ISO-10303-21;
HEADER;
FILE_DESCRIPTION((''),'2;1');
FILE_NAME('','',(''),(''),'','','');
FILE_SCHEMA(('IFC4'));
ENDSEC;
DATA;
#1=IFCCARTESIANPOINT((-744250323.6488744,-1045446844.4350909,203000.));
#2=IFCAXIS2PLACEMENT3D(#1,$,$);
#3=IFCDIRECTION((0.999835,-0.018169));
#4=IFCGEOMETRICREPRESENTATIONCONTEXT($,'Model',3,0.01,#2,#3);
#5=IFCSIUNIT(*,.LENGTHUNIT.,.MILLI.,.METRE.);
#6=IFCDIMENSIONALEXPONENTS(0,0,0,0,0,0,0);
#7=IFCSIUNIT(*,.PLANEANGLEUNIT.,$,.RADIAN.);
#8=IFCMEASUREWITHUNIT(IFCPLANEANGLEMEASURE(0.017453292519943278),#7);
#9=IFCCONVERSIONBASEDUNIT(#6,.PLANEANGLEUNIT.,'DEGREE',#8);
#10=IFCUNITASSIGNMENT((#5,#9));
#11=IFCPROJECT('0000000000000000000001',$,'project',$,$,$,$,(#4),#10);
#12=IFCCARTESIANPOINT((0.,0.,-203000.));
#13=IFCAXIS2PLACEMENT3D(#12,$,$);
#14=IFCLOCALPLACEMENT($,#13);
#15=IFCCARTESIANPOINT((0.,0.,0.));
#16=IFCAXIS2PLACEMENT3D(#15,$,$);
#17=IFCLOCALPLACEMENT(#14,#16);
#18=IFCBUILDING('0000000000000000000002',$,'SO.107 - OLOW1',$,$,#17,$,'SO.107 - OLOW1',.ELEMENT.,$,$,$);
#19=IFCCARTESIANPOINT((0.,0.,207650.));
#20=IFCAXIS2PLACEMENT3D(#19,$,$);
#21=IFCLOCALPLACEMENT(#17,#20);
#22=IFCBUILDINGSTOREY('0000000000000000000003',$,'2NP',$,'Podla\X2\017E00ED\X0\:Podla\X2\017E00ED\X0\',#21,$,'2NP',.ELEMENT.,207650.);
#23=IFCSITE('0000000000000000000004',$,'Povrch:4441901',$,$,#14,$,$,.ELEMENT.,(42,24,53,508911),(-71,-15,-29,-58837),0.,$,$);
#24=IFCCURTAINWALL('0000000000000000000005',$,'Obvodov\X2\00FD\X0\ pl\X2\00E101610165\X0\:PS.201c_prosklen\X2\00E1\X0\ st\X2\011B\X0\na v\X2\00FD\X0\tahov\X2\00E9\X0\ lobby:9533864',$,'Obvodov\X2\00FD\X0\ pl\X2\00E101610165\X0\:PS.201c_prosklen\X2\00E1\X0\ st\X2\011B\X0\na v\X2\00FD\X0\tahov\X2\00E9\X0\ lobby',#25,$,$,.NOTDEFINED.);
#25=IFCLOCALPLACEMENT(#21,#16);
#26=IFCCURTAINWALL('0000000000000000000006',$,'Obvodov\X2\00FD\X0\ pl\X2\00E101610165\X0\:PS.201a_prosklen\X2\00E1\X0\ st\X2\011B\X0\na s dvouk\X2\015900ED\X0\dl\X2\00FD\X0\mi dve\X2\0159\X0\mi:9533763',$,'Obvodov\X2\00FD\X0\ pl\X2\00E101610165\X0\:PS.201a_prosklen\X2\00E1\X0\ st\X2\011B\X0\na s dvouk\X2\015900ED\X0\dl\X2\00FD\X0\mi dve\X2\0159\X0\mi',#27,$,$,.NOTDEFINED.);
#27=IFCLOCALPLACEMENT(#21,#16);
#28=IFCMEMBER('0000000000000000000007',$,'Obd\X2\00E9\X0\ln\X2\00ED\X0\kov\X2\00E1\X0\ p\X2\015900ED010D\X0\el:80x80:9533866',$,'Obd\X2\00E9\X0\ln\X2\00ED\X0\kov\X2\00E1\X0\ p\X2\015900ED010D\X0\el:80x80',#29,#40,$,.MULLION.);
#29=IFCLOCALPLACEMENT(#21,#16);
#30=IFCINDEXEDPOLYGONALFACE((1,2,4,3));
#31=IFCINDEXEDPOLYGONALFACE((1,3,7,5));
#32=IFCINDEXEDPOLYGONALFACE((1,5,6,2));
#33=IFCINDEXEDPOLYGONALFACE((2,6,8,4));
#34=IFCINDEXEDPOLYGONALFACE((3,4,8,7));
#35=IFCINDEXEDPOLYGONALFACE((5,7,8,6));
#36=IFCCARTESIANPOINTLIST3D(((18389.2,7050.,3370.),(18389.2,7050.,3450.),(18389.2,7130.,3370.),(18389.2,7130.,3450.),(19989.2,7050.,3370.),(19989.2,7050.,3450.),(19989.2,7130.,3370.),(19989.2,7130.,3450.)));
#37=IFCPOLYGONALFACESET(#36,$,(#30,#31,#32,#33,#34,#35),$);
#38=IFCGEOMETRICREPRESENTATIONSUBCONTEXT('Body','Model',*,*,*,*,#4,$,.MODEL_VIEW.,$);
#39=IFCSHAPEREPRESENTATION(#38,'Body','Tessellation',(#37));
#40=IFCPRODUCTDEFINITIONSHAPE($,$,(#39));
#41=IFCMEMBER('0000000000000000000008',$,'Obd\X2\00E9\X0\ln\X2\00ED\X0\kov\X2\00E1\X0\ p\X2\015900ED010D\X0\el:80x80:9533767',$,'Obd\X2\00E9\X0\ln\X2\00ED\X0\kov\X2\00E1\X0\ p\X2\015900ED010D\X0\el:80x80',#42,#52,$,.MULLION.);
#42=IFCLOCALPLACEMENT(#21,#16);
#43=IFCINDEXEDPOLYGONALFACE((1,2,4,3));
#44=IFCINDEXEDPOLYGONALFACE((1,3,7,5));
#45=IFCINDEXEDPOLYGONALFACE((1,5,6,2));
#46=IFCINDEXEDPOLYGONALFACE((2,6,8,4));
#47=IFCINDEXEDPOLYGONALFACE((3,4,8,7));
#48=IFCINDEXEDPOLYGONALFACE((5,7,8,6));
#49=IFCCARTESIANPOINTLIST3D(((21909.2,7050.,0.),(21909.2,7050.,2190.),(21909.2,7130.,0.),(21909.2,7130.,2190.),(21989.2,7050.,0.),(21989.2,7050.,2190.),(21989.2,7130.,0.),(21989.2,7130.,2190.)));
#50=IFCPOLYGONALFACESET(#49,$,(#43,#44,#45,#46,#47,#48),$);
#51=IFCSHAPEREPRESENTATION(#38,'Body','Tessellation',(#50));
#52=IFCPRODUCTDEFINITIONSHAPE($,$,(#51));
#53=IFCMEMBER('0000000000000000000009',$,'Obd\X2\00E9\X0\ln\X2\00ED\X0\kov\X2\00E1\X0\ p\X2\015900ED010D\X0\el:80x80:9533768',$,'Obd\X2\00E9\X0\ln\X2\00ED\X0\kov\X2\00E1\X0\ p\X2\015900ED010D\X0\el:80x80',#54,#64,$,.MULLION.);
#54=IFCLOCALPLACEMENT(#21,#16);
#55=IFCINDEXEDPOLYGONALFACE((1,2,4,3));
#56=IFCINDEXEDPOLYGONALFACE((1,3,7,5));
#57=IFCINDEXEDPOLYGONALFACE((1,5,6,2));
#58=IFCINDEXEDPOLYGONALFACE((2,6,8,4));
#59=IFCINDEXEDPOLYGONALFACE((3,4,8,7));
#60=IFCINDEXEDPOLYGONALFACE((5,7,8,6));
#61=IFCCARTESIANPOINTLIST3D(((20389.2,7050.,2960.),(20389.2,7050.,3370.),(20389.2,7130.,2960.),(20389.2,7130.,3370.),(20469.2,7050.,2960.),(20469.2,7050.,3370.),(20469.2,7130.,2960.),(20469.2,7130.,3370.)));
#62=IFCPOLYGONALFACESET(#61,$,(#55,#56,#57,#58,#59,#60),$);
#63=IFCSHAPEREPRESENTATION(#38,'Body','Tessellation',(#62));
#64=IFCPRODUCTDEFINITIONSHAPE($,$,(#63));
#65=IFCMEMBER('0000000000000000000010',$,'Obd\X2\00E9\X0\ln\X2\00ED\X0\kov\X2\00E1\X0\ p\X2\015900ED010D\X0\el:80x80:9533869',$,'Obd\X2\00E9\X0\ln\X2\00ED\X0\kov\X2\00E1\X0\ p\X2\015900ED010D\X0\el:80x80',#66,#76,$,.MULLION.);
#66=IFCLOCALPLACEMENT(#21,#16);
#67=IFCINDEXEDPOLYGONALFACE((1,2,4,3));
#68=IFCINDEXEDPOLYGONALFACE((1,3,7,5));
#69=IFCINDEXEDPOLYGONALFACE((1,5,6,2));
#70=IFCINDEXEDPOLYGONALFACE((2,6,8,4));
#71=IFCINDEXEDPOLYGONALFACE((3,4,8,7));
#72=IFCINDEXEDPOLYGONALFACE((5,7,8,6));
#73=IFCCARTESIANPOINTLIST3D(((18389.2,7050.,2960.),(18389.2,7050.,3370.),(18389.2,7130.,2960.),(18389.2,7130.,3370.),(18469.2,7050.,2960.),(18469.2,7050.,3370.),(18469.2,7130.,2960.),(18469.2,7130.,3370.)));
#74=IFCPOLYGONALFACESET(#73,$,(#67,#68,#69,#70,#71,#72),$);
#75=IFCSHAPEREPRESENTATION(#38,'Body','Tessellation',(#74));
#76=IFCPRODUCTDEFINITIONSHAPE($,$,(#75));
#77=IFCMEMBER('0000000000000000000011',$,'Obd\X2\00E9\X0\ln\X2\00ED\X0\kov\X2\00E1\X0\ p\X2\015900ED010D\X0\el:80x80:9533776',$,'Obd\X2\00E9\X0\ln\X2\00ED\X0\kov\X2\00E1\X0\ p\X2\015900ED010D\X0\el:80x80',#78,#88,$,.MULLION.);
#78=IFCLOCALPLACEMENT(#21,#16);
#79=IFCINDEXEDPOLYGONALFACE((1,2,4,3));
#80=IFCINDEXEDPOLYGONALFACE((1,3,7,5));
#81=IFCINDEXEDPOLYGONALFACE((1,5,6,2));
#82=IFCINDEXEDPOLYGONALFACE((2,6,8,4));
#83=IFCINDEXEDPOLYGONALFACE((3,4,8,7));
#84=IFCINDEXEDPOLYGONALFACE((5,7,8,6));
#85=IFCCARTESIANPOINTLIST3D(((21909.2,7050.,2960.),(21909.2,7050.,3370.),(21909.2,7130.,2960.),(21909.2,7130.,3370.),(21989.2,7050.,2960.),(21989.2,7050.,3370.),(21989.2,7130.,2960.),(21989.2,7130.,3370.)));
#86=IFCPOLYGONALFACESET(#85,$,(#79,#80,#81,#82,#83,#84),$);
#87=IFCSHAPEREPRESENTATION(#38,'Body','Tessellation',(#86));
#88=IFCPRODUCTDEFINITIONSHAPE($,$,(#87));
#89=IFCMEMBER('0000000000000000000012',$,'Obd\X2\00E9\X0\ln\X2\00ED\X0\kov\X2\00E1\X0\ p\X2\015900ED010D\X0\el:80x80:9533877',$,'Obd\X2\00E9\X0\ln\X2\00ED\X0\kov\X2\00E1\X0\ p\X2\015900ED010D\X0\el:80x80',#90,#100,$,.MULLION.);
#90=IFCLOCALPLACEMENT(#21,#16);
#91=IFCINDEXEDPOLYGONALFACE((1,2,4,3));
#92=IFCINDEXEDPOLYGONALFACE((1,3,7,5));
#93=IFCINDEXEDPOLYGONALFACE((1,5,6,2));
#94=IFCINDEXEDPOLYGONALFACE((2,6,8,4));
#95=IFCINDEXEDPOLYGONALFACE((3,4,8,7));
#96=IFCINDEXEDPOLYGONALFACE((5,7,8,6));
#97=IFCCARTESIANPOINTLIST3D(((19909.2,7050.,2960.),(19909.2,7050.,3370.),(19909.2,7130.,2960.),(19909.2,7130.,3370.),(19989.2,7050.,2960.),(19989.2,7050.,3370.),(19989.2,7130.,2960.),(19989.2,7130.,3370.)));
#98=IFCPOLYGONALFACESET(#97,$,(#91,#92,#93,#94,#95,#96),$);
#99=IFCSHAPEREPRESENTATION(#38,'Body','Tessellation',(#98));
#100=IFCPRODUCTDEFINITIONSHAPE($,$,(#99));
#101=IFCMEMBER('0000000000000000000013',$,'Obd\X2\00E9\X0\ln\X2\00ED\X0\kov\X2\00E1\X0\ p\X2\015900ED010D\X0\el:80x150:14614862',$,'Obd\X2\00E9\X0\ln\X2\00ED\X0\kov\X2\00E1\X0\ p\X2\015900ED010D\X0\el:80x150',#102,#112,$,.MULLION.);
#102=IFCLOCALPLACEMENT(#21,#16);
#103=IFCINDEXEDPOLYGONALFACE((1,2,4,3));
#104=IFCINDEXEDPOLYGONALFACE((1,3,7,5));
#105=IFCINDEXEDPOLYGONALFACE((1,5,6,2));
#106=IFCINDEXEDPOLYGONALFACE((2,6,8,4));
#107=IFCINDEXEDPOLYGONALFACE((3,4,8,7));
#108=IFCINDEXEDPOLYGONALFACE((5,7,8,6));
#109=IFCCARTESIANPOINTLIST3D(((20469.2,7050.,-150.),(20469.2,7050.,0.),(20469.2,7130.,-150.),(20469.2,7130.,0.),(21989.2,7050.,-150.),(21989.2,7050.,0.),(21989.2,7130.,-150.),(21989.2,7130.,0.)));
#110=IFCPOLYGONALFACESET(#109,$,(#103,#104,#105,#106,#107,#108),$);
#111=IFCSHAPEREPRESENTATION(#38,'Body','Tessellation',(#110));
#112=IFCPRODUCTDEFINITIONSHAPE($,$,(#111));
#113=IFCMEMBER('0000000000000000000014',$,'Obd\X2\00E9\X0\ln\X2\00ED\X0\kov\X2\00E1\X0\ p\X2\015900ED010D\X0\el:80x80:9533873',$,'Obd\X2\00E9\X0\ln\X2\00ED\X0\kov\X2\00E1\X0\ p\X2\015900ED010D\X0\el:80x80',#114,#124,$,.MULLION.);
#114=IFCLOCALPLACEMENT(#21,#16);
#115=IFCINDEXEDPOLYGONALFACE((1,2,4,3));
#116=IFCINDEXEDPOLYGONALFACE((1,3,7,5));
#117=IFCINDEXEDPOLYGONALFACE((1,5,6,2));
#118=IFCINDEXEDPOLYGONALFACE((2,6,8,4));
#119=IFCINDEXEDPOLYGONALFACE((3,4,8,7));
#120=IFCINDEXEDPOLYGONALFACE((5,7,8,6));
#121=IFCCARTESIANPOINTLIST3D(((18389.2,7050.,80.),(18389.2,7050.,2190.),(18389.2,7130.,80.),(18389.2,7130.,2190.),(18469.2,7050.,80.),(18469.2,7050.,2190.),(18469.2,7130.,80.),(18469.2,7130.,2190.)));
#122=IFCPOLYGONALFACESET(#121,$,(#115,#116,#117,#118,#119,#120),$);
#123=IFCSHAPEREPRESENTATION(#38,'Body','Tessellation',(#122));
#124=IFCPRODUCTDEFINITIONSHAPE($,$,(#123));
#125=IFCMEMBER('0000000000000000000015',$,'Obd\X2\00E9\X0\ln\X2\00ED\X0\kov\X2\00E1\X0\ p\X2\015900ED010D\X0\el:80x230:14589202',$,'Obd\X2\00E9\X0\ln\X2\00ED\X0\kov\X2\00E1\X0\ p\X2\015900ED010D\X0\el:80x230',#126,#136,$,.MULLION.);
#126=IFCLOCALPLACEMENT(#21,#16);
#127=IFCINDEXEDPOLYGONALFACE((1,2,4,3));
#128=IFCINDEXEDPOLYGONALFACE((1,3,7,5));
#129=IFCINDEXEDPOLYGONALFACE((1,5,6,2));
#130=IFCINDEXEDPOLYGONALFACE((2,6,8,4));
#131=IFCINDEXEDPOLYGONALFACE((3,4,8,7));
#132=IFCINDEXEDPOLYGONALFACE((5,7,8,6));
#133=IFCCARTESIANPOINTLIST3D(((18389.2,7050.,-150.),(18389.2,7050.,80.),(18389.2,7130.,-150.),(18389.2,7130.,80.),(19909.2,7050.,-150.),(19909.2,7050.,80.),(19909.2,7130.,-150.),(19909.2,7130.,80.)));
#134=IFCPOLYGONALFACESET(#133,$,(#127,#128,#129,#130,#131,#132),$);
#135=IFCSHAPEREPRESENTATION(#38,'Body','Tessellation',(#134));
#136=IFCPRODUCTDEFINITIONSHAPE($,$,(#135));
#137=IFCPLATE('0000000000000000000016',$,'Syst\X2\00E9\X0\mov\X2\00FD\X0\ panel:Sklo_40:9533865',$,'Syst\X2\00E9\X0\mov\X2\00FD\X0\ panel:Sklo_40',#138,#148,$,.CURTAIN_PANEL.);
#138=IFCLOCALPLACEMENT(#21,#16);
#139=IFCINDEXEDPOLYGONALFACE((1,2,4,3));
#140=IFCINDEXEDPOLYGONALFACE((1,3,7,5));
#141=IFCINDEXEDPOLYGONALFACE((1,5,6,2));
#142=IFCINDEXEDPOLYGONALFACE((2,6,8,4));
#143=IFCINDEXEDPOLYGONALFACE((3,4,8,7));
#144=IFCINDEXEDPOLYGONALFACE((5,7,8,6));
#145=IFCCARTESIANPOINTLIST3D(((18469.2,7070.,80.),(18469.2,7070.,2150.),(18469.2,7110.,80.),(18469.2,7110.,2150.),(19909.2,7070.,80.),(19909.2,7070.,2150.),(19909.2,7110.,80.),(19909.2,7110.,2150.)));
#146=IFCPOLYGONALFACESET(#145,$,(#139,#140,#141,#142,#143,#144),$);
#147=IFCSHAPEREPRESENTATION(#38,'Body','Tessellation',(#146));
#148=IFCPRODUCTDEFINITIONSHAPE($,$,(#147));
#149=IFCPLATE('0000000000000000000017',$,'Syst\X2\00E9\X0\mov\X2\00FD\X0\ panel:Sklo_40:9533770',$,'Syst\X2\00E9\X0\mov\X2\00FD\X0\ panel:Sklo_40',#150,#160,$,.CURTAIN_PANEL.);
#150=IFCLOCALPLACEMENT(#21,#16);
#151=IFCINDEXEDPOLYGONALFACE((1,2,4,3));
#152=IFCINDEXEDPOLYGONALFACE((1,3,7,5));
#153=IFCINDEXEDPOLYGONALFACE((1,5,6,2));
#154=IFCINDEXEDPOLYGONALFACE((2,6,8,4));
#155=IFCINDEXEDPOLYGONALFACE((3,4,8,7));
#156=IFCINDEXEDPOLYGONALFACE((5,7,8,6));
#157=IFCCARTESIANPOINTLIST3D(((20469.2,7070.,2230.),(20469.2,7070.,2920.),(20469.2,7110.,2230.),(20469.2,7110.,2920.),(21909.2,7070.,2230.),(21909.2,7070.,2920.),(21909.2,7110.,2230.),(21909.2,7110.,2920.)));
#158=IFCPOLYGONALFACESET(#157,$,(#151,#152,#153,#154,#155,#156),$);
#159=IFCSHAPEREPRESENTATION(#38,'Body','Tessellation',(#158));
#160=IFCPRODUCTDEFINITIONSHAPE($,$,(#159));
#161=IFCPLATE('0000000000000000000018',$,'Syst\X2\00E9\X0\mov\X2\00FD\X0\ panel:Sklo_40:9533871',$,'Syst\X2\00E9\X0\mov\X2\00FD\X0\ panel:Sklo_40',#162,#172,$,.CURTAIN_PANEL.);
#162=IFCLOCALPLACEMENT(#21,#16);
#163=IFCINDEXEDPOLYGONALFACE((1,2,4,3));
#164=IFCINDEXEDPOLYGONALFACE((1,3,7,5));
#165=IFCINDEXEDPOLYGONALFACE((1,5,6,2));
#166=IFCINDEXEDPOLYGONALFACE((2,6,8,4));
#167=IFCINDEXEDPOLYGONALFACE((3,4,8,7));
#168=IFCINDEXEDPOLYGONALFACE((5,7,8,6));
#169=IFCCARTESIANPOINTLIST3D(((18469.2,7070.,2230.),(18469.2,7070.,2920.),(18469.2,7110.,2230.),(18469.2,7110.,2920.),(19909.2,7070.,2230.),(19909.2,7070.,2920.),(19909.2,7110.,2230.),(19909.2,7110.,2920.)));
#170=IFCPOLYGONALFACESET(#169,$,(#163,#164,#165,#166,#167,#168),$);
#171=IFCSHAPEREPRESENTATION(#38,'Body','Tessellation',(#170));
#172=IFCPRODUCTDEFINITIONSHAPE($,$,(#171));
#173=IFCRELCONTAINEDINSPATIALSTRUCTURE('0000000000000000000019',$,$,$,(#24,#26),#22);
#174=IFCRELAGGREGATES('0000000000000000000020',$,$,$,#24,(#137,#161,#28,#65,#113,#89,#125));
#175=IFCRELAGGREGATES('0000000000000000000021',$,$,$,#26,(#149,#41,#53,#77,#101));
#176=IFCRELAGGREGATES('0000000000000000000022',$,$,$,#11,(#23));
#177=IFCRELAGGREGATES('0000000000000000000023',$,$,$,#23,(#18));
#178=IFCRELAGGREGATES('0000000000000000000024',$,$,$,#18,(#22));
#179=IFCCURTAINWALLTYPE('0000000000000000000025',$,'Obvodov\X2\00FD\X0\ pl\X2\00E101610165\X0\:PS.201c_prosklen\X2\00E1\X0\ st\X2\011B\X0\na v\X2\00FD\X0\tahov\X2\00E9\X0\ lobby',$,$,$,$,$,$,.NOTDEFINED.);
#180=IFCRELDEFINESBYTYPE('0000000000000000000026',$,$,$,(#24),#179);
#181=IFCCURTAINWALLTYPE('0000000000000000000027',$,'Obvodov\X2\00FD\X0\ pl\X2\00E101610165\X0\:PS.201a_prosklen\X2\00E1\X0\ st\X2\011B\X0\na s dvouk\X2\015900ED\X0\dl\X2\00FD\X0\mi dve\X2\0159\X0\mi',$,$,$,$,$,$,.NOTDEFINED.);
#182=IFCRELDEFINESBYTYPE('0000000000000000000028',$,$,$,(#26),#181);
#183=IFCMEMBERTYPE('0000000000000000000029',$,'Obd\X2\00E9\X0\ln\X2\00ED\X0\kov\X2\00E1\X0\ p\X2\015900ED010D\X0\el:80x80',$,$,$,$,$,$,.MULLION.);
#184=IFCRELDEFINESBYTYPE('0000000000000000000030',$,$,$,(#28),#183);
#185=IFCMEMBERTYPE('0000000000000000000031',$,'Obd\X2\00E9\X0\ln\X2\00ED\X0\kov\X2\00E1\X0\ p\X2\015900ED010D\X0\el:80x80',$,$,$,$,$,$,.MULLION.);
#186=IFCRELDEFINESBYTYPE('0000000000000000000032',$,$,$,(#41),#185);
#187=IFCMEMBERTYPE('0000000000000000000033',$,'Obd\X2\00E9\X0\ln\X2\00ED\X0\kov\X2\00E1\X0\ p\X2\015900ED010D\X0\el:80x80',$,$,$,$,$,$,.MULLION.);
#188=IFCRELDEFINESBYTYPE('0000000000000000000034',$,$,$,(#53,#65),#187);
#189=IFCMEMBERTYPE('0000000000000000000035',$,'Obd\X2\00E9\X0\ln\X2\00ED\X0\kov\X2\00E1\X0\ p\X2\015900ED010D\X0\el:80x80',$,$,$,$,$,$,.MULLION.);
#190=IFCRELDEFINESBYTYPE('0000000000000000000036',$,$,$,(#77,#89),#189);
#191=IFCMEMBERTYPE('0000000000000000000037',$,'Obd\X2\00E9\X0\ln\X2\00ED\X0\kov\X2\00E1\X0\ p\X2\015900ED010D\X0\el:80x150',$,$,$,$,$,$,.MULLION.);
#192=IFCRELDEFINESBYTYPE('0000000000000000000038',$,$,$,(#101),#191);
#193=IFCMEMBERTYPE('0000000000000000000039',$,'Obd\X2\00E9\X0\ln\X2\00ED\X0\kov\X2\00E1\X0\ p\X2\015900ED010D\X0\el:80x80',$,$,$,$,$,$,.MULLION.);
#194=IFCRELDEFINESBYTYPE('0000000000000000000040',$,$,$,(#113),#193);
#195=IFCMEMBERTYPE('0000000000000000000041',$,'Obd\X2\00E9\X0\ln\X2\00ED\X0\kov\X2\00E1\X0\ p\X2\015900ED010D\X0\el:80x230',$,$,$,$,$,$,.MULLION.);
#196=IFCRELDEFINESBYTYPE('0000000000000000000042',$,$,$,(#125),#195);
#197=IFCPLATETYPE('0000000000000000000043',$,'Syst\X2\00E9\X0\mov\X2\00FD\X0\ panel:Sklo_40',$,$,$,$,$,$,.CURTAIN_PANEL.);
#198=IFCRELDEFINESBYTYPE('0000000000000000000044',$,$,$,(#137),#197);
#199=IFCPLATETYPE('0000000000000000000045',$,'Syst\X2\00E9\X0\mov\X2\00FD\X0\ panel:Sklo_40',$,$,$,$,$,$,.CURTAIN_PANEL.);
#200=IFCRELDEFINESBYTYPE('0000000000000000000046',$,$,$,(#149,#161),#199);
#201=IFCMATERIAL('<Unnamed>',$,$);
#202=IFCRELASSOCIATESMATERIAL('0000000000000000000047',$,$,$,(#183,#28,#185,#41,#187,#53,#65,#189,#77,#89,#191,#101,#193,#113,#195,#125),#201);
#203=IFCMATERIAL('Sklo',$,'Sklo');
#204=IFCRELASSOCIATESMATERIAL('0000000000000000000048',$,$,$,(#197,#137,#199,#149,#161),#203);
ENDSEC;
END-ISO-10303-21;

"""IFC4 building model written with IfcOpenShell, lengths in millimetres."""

from ifc_helpers import new_model, entity, si_unit, converted_unit, direction, frame, origin, place, context, subcontext, project, spatial, indexed_curve, outline, extrude, source, transform, mapped, material, type_object, type_shapes, element, aggregate, save


model = new_model("IFC4")

# Units and contexts
model_context = context("Model", 3, precision=0.01, world=frame((-744250323.6488744, -1045446844.4350909, 203000.0)), true_north=direction((0.999835, -0.018169)))
body_context = subcontext(model_context, "Body", "Model", "MODEL_VIEW")
ifc_project = project(units=[si_unit("LENGTHUNIT", "METRE", prefix="MILLI"), converted_unit("PLANEANGLEUNIT", "DEGREE", entity("IfcPlaneAngleMeasure", 0.017453292519943278), si_unit("PLANEANGLEUNIT", "RADIAN"), dimensions=[0, 0, 0, 0, 0, 0, 0])], contexts=[model_context])

# Site, building, storey
site_placement = place(None, frame((0.0, 0.0, -203000.0)))
site = spatial("IfcSite", under=ifc_project, at=site_placement, Name="Povrch:4441901", CompositionType="ELEMENT", RefLatitude=(42, 24, 53, 508911), RefLongitude=(-71, -15, -29, -58837), RefElevation=0.0)
building_placement = place(site_placement, origin())
building = spatial("IfcBuilding", under=site, at=building_placement, Name="SO.107 - OLOW1", LongName="SO.107 - OLOW1", CompositionType="ELEMENT")
storey_placement = place(building_placement, frame((0.0, 0.0, 207650.0)))
storey = spatial("IfcBuildingStorey", under=building, at=storey_placement, Name="2NP", ObjectType="Podlaží:Podlaží", LongName="2NP", CompositionType="ELEMENT", Elevation=207650.0)

# Curtain walls
ifc_material_1 = material(Name="<Unnamed>")
curtain_wall_type_1 = type_object("IfcCurtainWallType", Name="Obvodový plášť:PS.201c_prosklená stěna výtahové lobby", PredefinedType="NOTDEFINED")
curtain_wall_1_placement = place(storey_placement, frame((0.0, 0.0, -207650.0)))
curtain_wall_1 = element("IfcCurtainWall", 1, at=curtain_wall_1_placement, inside=storey, type_object=curtain_wall_type_1, Name="Obvodový plášť:PS.201c_prosklená stěna výtahové lobby:9533864", ObjectType="Obvodový plášť:PS.201c_prosklená stěna výtahové lobby", PredefinedType="NOTDEFINED")
curtain_wall_type_2 = type_object("IfcCurtainWallType", Name="Obvodový plášť:PS.201a_prosklená stěna s dvoukřídlými dveřmi", PredefinedType="NOTDEFINED")
curtain_wall_2_placement = place(storey_placement, frame((0.0, 0.0, -207650.0)))
curtain_wall_2 = element("IfcCurtainWall", 2, at=curtain_wall_2_placement, inside=storey, type_object=curtain_wall_type_2, Name="Obvodový plášť:PS.201a_prosklená stěna s dvoukřídlými dveřmi:9533763", ObjectType="Obvodový plášť:PS.201a_prosklená stěna s dvoukřídlými dveřmi", PredefinedType="NOTDEFINED")

# Members
member_type_1 = type_object("IfcMemberType", Name="Obdélníková příčel:80x80", PredefinedType="MULLION", material=ifc_material_1)
shared_shape_1 = source(origin(), body_context, "Body", "SweptSolid", [
    extrude(outline(indexed_curve([(-40.0, -40.0), (40.0, -40.0), (40.0, 40.0), (-40.0, 40.0), (-40.0, -40.0)], self_intersect=False)), frame((-40.0, 0.0, -1600.0), z_axis=(0.0, 0.0, 1.0), x_axis=(-1.0, 0.0, 0.0)), (0.0, 0.0, 1.0), 1600.0),
])
type_shapes(member_type_1, [shared_shape_1])
member_1_placement = place(curtain_wall_1_placement, frame((19989.2, 7090.0, 211100.0), z_axis=(1.0, 0.0, 0.0), x_axis=(0.0, 0.0, 1.0)))
member_1 = element("IfcMember", 3, at=member_1_placement, type_object=member_type_1, material=ifc_material_1, Name="Obdélníková příčel:80x80:9533866", ObjectType="Obdélníková příčel:80x80", PredefinedType="MULLION", context=body_context, shape_type="MappedRepresentation", body=[
    mapped(shared_shape_1, transform((0.0, 0.0, 0.0), scale=1.0)),
])
member_type_2 = type_object("IfcMemberType", Name="Obdélníková příčel:80x80", PredefinedType="MULLION", material=ifc_material_1)
shared_shape_2 = source(origin(), body_context, "Body", "SweptSolid", [
    extrude(outline(indexed_curve([(-40.0, -40.0), (40.0, -40.0), (40.0, 40.0), (-40.0, 40.0), (-40.0, -40.0)], self_intersect=False)), frame((-40.0, 0.0, -2190.0), z_axis=(0.0, 0.0, 1.0), x_axis=(-1.0, 0.0, 0.0)), (0.0, 0.0, 1.0), 2190.0),
])
type_shapes(member_type_2, [shared_shape_2])
member_2_placement = place(curtain_wall_2_placement, frame((21989.2, 7090.0, 207650.0), z_axis=(0.0, 0.0, -1.0), x_axis=(1.0, 0.0, 0.0)))
member_2 = element("IfcMember", 4, at=member_2_placement, type_object=member_type_2, material=ifc_material_1, Name="Obdélníková příčel:80x80:9533767", ObjectType="Obdélníková příčel:80x80", PredefinedType="MULLION", context=body_context, shape_type="MappedRepresentation", body=[
    mapped(shared_shape_2, transform((0.0, 0.0, 0.0), scale=1.0)),
])
member_type_3 = type_object("IfcMemberType", Name="Obdélníková příčel:80x80", PredefinedType="MULLION", material=ifc_material_1)
shared_shape_3 = source(origin(), body_context, "Body", "SweptSolid", [
    extrude(outline(indexed_curve([(-40.0, -40.0), (40.0, -40.0), (40.0, 40.0), (-40.0, 40.0), (-40.0, -40.0)], self_intersect=False)), frame((-40.0, 0.0, -410.0), z_axis=(0.0, 0.0, 1.0), x_axis=(-1.0, 0.0, 0.0)), (0.0, 0.0, 1.0), 410.0),
])
type_shapes(member_type_3, [shared_shape_3])
member_3_placement = place(curtain_wall_2_placement, frame((20389.2, 7090.0, 211020.0), z_axis=(0.0, 0.0, 1.0), x_axis=(-1.0, 0.0, 0.0)))
member_3 = element("IfcMember", 5, at=member_3_placement, type_object=member_type_3, material=ifc_material_1, Name="Obdélníková příčel:80x80:9533768", ObjectType="Obdélníková příčel:80x80", PredefinedType="MULLION", context=body_context, shape_type="MappedRepresentation", body=[
    mapped(shared_shape_3, transform((0.0, 0.0, 0.0), scale=1.0)),
])
member_4_placement = place(curtain_wall_1_placement, frame((18389.2, 7090.0, 211020.0), z_axis=(0.0, 0.0, 1.0), x_axis=(-1.0, 0.0, 0.0)))
member_4 = element("IfcMember", 6, at=member_4_placement, type_object=member_type_3, material=ifc_material_1, Name="Obdélníková příčel:80x80:9533869", ObjectType="Obdélníková příčel:80x80", PredefinedType="MULLION", context=body_context, shape_type="MappedRepresentation", body=[
    mapped(shared_shape_3, transform((0.0, 0.0, 0.0), scale=1.0)),
])
member_type_4 = type_object("IfcMemberType", Name="Obdélníková příčel:80x80", PredefinedType="MULLION", material=ifc_material_1)
shared_shape_4 = source(origin(), body_context, "Body", "SweptSolid", [
    extrude(outline(indexed_curve([(-40.0, -40.0), (40.0, -40.0), (40.0, 40.0), (-40.0, 40.0), (-40.0, -40.0)], self_intersect=False)), frame((-40.0, 0.0, -410.0), z_axis=(0.0, 0.0, 1.0), x_axis=(-1.0, 0.0, 0.0)), (0.0, 0.0, 1.0), 410.0),
])
type_shapes(member_type_4, [shared_shape_4])
member_5_placement = place(curtain_wall_2_placement, frame((21989.2, 7090.0, 210610.0), z_axis=(0.0, 0.0, -1.0), x_axis=(1.0, 0.0, 0.0)))
member_5 = element("IfcMember", 7, at=member_5_placement, type_object=member_type_4, material=ifc_material_1, Name="Obdélníková příčel:80x80:9533776", ObjectType="Obdélníková příčel:80x80", PredefinedType="MULLION", context=body_context, shape_type="MappedRepresentation", body=[
    mapped(shared_shape_4, transform((0.0, 0.0, 0.0), scale=1.0)),
])
member_6_placement = place(curtain_wall_1_placement, frame((19989.2, 7090.0, 210610.0), z_axis=(0.0, 0.0, -1.0), x_axis=(1.0, 0.0, 0.0)))
member_6 = element("IfcMember", 8, at=member_6_placement, type_object=member_type_4, material=ifc_material_1, Name="Obdélníková příčel:80x80:9533877", ObjectType="Obdélníková příčel:80x80", PredefinedType="MULLION", context=body_context, shape_type="MappedRepresentation", body=[
    mapped(shared_shape_4, transform((0.0, 0.0, 0.0), scale=1.0)),
])
member_type_5 = type_object("IfcMemberType", Name="Obdélníková příčel:80x150", PredefinedType="MULLION", material=ifc_material_1)
shared_shape_5 = source(origin(), body_context, "Body", "SweptSolid", [
    extrude(outline(indexed_curve([(-75.0, -40.0), (75.0, -40.0), (75.0, 40.0), (-75.0, 40.0), (-75.0, -40.0)], self_intersect=False)), frame((-75.0, 0.0, -1520.0), z_axis=(0.0, 0.0, 1.0), x_axis=(-1.0, 0.0, 0.0)), (0.0, 0.0, 1.0), 1520.0),
])
type_shapes(member_type_5, [shared_shape_5])
member_7_placement = place(curtain_wall_2_placement, frame((20469.2, 7090.0, 207500.0), z_axis=(-1.0, 0.0, 0.0), x_axis=(0.0, 0.0, -1.0)))
member_7 = element("IfcMember", 9, at=member_7_placement, type_object=member_type_5, material=ifc_material_1, Name="Obdélníková příčel:80x150:14614862", ObjectType="Obdélníková příčel:80x150", PredefinedType="MULLION", context=body_context, shape_type="MappedRepresentation", body=[
    mapped(shared_shape_5, transform((0.0, 0.0, 0.0), scale=1.0)),
])
member_type_6 = type_object("IfcMemberType", Name="Obdélníková příčel:80x80", PredefinedType="MULLION", material=ifc_material_1)
shared_shape_6 = source(origin(), body_context, "Body", "SweptSolid", [
    extrude(outline(indexed_curve([(-40.0, -40.0), (40.0, -40.0), (40.0, 40.0), (-40.0, 40.0), (-40.0, -40.0)], self_intersect=False)), frame((-40.0, 0.0, -2110.0), z_axis=(0.0, 0.0, 1.0), x_axis=(-1.0, 0.0, 0.0)), (0.0, 0.0, 1.0), 2110.0),
])
type_shapes(member_type_6, [shared_shape_6])
member_8_placement = place(curtain_wall_1_placement, frame((18389.2, 7090.0, 209840.0), z_axis=(0.0, 0.0, 1.0), x_axis=(-1.0, 0.0, 0.0)))
member_8 = element("IfcMember", 10, at=member_8_placement, type_object=member_type_6, material=ifc_material_1, Name="Obdélníková příčel:80x80:9533873", ObjectType="Obdélníková příčel:80x80", PredefinedType="MULLION", context=body_context, shape_type="MappedRepresentation", body=[
    mapped(shared_shape_6, transform((0.0, 0.0, 0.0), scale=1.0)),
])
member_type_7 = type_object("IfcMemberType", Name="Obdélníková příčel:80x230", PredefinedType="MULLION", material=ifc_material_1)
shared_shape_7 = source(origin(), body_context, "Body", "SweptSolid", [
    extrude(outline(indexed_curve([(-115.0, -40.0), (115.0, -40.0), (115.0, 40.0), (-115.0, 40.0), (-115.0, -40.0)], self_intersect=False)), frame((-115.0, 0.0, -1520.0), z_axis=(0.0, 0.0, 1.0), x_axis=(-1.0, 0.0, 0.0)), (0.0, 0.0, 1.0), 1520.0),
])
type_shapes(member_type_7, [shared_shape_7])
member_9_placement = place(curtain_wall_1_placement, frame((18389.2, 7090.0, 207500.0), z_axis=(-1.0, 0.0, 0.0), x_axis=(0.0, 0.0, -1.0)))
member_9 = element("IfcMember", 11, at=member_9_placement, type_object=member_type_7, material=ifc_material_1, Name="Obdélníková příčel:80x230:14589202", ObjectType="Obdélníková příčel:80x230", PredefinedType="MULLION", context=body_context, shape_type="MappedRepresentation", body=[
    mapped(shared_shape_7, transform((0.0, 0.0, 0.0), scale=1.0)),
])

# Plates
ifc_material_2 = material(Name="Sklo", Category="Sklo")
plate_type_1 = type_object("IfcPlateType", Name="Systémový panel:Sklo_40", PredefinedType="CURTAIN_PANEL", material=ifc_material_2)
shared_shape_8 = source(origin(), body_context, "Body", "SweptSolid", [
    extrude(outline(indexed_curve([(-20.0, -720.0), (20.0, -720.0), (20.0, 720.0), (-20.0, 720.0), (-20.0, -720.0)], self_intersect=False)), frame((0.0, 0.0, 0.0), z_axis=(0.0, 0.0, 1.0), x_axis=(0.0, 1.0, 0.0)), (0.0, 0.0, 1.0), 2070.0),
])
type_shapes(plate_type_1, [shared_shape_8])
plate_1_placement = place(curtain_wall_1_placement, frame((19189.2, 7090.0, 207730.0)))
plate_1 = element("IfcPlate", 12, at=plate_1_placement, type_object=plate_type_1, material=ifc_material_2, Name="Systémový panel:Sklo_40:9533865", ObjectType="Systémový panel:Sklo_40", PredefinedType="CURTAIN_PANEL", context=body_context, shape_type="MappedRepresentation", body=[
    mapped(shared_shape_8, transform((0.0, 0.0, 0.0), scale=1.0)),
])
plate_type_2 = type_object("IfcPlateType", Name="Systémový panel:Sklo_40", PredefinedType="CURTAIN_PANEL", material=ifc_material_2)
shared_shape_9 = source(origin(), body_context, "Body", "SweptSolid", [
    extrude(outline(indexed_curve([(-20.0, -720.0), (20.0, -720.0), (20.0, 720.0), (-20.0, 720.0), (-20.0, -720.0)], self_intersect=False)), frame((0.0, 0.0, 0.0), z_axis=(0.0, 0.0, 1.0), x_axis=(0.0, 1.0, 0.0)), (0.0, 0.0, 1.0), 690.0),
])
type_shapes(plate_type_2, [shared_shape_9])
plate_2_placement = place(curtain_wall_2_placement, frame((21189.2, 7090.0, 209880.0)))
plate_2 = element("IfcPlate", 13, at=plate_2_placement, type_object=plate_type_2, material=ifc_material_2, Name="Systémový panel:Sklo_40:9533770", ObjectType="Systémový panel:Sklo_40", PredefinedType="CURTAIN_PANEL", context=body_context, shape_type="MappedRepresentation", body=[
    mapped(shared_shape_9, transform((0.0, 0.0, 0.0), scale=1.0)),
])
plate_3_placement = place(curtain_wall_1_placement, frame((19189.2, 7090.0, 209880.0)))
plate_3 = element("IfcPlate", 14, at=plate_3_placement, type_object=plate_type_2, material=ifc_material_2, Name="Systémový panel:Sklo_40:9533871", ObjectType="Systémový panel:Sklo_40", PredefinedType="CURTAIN_PANEL", context=body_context, shape_type="MappedRepresentation", body=[
    mapped(shared_shape_9, transform((0.0, 0.0, 0.0), scale=1.0)),
])
aggregate(curtain_wall_1, [plate_1, plate_3, member_1, member_4, member_8, member_6, member_9])

aggregate(curtain_wall_2, [plate_2, member_2, member_3, member_5, member_7])

save(model, "model.ifc")
